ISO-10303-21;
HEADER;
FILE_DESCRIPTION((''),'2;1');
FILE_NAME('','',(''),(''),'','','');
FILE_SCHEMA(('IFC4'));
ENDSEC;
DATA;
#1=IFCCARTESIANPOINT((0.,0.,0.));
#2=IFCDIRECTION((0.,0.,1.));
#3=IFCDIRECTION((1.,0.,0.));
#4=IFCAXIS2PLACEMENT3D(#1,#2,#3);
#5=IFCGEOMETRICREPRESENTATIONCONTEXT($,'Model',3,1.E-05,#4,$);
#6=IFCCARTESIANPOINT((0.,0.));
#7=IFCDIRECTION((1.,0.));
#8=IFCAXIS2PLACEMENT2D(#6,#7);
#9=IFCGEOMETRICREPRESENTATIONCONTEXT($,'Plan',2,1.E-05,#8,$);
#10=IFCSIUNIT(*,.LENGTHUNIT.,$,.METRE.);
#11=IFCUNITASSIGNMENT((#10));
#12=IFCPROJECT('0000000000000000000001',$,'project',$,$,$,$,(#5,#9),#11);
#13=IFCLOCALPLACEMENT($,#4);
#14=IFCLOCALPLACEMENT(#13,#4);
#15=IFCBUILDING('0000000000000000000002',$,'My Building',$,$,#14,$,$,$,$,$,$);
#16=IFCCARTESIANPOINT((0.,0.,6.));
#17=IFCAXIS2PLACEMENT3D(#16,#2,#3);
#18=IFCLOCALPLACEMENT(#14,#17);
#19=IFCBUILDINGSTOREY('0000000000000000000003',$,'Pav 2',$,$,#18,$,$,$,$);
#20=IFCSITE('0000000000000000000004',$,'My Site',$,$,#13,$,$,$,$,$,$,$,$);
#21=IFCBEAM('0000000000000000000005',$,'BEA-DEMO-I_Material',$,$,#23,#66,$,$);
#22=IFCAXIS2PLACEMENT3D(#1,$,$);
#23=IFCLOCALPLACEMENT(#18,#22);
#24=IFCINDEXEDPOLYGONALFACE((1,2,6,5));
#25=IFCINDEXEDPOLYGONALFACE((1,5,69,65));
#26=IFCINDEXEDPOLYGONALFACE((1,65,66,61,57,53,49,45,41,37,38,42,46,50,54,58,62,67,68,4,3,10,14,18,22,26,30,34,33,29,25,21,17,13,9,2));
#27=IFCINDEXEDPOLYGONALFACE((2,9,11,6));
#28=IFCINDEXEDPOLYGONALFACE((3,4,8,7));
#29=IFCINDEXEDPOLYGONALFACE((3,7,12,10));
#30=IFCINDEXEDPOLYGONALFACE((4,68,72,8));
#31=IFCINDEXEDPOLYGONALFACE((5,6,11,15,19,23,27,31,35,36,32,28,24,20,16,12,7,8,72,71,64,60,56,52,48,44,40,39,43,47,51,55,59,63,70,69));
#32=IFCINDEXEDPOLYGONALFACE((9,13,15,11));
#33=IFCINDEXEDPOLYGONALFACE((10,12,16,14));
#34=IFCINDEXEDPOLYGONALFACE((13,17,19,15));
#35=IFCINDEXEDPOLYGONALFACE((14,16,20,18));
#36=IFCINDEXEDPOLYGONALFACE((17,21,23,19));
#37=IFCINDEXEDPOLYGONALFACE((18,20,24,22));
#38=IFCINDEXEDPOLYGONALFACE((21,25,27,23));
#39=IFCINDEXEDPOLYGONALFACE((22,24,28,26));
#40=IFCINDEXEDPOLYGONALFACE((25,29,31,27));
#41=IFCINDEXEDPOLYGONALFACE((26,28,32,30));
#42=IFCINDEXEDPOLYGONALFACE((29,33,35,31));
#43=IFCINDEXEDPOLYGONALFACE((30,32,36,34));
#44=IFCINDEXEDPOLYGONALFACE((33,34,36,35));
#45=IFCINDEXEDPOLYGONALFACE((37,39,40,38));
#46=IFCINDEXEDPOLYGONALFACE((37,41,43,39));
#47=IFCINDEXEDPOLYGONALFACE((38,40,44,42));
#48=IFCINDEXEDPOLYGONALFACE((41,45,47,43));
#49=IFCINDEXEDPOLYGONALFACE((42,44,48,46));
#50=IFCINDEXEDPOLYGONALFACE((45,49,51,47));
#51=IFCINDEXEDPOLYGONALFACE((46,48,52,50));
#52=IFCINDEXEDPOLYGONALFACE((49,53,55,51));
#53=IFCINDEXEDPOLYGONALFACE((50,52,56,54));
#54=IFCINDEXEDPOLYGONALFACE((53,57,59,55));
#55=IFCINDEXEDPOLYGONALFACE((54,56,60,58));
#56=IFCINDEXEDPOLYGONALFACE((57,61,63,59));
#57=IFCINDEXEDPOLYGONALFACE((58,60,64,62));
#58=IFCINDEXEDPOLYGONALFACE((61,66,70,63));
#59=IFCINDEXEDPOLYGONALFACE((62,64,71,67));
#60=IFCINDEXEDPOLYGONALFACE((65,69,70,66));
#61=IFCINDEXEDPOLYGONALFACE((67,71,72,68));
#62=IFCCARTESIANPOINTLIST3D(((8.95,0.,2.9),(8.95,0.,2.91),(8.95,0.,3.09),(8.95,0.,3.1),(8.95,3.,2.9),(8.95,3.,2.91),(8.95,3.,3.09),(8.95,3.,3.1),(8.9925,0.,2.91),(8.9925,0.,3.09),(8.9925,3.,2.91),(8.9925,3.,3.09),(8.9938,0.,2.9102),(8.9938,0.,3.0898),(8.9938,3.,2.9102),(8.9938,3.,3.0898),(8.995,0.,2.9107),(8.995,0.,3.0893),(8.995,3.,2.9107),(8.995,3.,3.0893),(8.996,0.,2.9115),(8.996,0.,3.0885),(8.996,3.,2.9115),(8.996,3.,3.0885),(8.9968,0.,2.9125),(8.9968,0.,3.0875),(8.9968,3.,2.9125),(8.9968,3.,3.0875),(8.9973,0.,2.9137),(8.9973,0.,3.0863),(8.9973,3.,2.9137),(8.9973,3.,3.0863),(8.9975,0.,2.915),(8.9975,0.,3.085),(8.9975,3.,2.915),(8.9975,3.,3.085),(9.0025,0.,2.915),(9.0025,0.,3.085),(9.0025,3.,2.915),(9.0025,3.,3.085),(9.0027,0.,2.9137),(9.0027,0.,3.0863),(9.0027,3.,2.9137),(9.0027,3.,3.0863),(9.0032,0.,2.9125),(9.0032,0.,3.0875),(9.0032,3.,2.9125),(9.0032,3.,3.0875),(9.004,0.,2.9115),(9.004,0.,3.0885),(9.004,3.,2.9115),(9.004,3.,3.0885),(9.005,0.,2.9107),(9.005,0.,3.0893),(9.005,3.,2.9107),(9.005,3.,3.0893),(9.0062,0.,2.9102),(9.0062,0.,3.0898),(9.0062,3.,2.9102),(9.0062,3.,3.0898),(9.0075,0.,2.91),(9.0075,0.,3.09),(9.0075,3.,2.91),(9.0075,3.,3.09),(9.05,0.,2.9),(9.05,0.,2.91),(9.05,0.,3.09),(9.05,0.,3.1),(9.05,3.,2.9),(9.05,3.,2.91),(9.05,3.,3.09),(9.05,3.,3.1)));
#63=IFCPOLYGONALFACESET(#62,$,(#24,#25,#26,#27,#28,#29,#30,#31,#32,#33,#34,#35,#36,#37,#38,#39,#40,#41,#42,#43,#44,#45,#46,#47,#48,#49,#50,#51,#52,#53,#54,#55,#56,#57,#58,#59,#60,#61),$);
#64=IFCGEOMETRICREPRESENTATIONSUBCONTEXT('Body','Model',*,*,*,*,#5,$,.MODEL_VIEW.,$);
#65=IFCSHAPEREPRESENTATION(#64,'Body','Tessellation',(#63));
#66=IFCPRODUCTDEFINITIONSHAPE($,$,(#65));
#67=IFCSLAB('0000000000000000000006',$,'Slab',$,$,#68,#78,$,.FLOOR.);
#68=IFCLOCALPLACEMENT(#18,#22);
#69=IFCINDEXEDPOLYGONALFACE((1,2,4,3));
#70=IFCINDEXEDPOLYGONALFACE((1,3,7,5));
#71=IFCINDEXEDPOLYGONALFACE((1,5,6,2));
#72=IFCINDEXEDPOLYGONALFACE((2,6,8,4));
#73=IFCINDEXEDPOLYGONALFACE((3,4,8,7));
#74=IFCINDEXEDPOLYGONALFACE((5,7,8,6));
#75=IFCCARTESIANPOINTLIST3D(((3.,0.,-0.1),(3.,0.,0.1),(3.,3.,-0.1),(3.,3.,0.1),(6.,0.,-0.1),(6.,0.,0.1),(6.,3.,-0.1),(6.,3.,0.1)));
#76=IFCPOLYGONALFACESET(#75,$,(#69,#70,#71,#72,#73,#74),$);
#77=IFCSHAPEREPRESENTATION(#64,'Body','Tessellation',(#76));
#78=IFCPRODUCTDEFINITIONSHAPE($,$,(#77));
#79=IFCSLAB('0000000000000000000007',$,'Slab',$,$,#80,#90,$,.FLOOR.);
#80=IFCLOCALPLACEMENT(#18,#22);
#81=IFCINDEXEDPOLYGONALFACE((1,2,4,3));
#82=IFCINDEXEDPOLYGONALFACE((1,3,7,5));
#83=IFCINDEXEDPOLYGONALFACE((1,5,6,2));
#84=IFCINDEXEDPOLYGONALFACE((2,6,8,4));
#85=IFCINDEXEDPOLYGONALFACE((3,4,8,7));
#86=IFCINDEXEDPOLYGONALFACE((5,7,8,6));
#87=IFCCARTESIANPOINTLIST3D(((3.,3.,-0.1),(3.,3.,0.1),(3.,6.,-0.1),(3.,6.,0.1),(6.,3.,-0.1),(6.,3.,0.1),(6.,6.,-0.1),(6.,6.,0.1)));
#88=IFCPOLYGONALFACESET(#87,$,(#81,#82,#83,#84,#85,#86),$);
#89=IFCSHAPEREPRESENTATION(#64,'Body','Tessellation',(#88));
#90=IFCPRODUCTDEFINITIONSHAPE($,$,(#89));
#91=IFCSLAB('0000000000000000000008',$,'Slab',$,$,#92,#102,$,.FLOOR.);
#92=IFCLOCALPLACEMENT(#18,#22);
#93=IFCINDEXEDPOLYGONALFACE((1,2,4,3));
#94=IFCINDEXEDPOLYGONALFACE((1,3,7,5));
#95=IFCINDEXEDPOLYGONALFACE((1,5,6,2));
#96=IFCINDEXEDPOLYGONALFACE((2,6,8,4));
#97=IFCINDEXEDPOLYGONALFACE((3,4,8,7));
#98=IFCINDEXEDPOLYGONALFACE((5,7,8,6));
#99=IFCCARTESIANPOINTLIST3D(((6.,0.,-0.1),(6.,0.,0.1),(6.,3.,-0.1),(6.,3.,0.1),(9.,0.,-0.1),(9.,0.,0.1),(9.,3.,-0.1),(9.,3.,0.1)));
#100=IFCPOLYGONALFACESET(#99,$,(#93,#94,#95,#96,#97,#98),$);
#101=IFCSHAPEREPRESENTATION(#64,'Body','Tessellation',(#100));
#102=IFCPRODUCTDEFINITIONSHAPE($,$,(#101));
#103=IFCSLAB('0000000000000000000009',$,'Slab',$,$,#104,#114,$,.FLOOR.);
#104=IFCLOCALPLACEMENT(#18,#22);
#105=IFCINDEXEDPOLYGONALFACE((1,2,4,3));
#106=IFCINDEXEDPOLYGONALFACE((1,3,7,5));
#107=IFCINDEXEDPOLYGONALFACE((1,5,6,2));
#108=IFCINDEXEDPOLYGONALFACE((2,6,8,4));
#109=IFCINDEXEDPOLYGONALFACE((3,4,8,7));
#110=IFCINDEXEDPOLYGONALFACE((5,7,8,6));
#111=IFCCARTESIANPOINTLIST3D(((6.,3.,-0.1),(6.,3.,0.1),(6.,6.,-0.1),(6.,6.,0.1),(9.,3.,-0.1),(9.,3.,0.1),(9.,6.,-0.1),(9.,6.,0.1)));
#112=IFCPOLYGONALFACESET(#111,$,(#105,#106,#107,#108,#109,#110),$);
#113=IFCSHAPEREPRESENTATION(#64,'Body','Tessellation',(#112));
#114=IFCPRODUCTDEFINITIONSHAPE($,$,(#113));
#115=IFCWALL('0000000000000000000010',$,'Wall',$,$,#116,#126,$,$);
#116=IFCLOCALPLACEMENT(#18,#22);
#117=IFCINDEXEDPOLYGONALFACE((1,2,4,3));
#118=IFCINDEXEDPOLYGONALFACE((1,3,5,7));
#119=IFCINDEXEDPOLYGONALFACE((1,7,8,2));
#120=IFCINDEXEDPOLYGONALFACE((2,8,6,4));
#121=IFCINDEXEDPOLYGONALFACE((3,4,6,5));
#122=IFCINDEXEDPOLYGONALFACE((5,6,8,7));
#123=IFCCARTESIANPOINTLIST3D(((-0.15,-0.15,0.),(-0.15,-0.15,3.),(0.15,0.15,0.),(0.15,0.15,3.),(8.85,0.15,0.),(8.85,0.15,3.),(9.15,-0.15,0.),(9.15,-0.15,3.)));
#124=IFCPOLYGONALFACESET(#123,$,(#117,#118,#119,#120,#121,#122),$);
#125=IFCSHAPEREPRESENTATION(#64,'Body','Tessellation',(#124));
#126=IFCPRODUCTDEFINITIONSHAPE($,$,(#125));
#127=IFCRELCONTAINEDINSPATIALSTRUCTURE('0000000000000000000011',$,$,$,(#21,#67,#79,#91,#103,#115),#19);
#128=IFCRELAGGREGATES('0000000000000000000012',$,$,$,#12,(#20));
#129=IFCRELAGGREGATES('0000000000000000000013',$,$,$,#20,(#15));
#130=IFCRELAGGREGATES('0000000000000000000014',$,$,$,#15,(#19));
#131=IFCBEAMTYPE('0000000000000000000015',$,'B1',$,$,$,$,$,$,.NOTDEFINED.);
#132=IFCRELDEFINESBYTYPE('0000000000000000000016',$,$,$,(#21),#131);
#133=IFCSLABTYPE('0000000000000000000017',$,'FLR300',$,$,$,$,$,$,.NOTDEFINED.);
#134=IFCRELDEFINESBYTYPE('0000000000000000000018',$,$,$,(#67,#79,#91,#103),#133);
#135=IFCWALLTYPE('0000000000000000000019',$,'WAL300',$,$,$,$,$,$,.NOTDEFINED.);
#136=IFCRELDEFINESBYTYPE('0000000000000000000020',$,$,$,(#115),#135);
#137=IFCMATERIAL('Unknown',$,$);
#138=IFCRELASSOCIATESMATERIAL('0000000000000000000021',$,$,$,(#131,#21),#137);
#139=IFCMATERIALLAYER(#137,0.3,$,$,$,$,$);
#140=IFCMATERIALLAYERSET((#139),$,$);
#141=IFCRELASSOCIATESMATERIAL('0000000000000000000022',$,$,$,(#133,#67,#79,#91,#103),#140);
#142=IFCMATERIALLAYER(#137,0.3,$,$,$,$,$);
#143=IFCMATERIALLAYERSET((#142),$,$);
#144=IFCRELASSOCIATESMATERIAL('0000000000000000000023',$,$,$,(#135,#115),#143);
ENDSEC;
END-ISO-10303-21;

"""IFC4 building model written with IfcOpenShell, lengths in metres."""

from ifc_helpers import new_model, si_unit, frame, origin, origin_with_axes, origin_2d_with_axis, place, context, subcontext, project, spatial, polyline, line, indexed_curve, i_section, outline, extrude, material, layer, layer_set, layer_usage, material_profile, profile_set, profile_usage, type_object, element, save


model = new_model("IFC4")

# Units and contexts
model_context = context("Model", 3, precision=1e-05, world=origin_with_axes())
plan_context = context("Plan", 2, precision=1e-05, world=origin_2d_with_axis())
body_context = subcontext(model_context, "Body", "Model", "MODEL_VIEW")
ifc_project = project(units=[si_unit("LENGTHUNIT", "METRE")], contexts=[model_context, plan_context])

# Site, building, storey
site_placement = place(None, origin_with_axes())
site = spatial("IfcSite", under=ifc_project, at=site_placement, Name="My Site")
building_placement = place(site_placement, origin_with_axes())
building = spatial("IfcBuilding", under=site, at=building_placement, Name="My Building")
storey_placement = place(building_placement, frame((0.0, 0.0, 6.0), z_axis=(0.0, 0.0, 1.0), x_axis=(1.0, 0.0, 0.0)))
storey = spatial("IfcBuildingStorey", under=building, at=storey_placement, Name="Pav 2")

# Beam
ifc_material = material(Name="Unknown")
ifc_material_profile = material_profile(ifc_material, i_section(OverallWidth=0.1, OverallDepth=0.2, WebThickness=0.005, FlangeThickness=0.01, FilletRadius=0.005))
ifc_profile_set = profile_set([ifc_material_profile])
beam_type = type_object("IfcBeamType", Name="B1", PredefinedType="NOTDEFINED", material=ifc_profile_set)
ifc_profile_usage_1 = profile_usage(ifc_profile_set, cardinal=5)
beam_1_placement = place(storey_placement, frame((9.0, 3.0, 3.0), z_axis=(0.0, -1.0, 0.0), x_axis=(1.0, 0.0, 0.0)))
element("IfcBeam", 1, at=beam_1_placement, inside=storey, type_object=beam_type, material=ifc_profile_usage_1, Name="BEA-DEMO-I_Material", context=body_context, shape_type="SweptSolid", body=[
    extrude(i_section(OverallWidth=0.1, OverallDepth=0.2, WebThickness=0.005, FlangeThickness=0.01, FilletRadius=0.005), origin(), (0.0, 0.0, 1.0), 3.0),
])

# Slabs
ifc_layer_1 = layer(ifc_material, 0.3)
ifc_layer_set_1 = layer_set([ifc_layer_1])
ifc_layer_usage_1 = layer_usage(ifc_layer_set_1, "AXIS3", "POSITIVE", 0.0)
slab_type = type_object("IfcSlabType", Name="FLR300", PredefinedType="NOTDEFINED", material=ifc_layer_set_1)
slab_1_placement = place(storey_placement, frame((4.5, 1.5, -0.1), z_axis=(0.0, 0.0, 1.0), x_axis=(1.0, 0.0, 0.0)))
element("IfcSlab", 2, at=slab_1_placement, inside=storey, type_object=slab_type, material=ifc_layer_usage_1, Name="Slab", PredefinedType="FLOOR", context=body_context, shape_type="SweptSolid", body=[
    extrude(outline(polyline([(1.5, 1.5), (-1.5, 1.5), (-1.5, -1.5), (1.5, -1.5), (1.5, 1.5)])), origin(), (0.0, 0.0, 1.0), 0.2),
])
ifc_layer_usage_2 = layer_usage(ifc_layer_set_1, "AXIS3", "POSITIVE", 0.0)
slab_2_placement = place(storey_placement, frame((4.5, 4.5, -0.1), z_axis=(0.0, 0.0, 1.0), x_axis=(1.0, 0.0, 0.0)))
element("IfcSlab", 3, at=slab_2_placement, inside=storey, type_object=slab_type, material=ifc_layer_usage_2, Name="Slab", PredefinedType="FLOOR", context=body_context, shape_type="SweptSolid", body=[
    extrude(outline(polyline([(1.5, 1.5), (-1.5, 1.5), (-1.5, -1.5), (1.5, -1.5), (1.5, 1.5)])), origin(), (0.0, 0.0, 1.0), 0.2),
])
ifc_layer_usage_3 = layer_usage(ifc_layer_set_1, "AXIS3", "POSITIVE", 0.0)
slab_3_placement = place(storey_placement, frame((7.5, 1.5, -0.1), z_axis=(0.0, 0.0, 1.0), x_axis=(1.0, 0.0, 0.0)))
element("IfcSlab", 4, at=slab_3_placement, inside=storey, type_object=slab_type, material=ifc_layer_usage_3, Name="Slab", PredefinedType="FLOOR", context=body_context, shape_type="SweptSolid", body=[
    extrude(outline(polyline([(1.5, 1.5), (-1.5, 1.5), (-1.5, -1.5), (1.5, -1.5), (1.5, 1.5)])), origin(), (0.0, 0.0, 1.0), 0.2),
])
ifc_layer_usage_4 = layer_usage(ifc_layer_set_1, "AXIS3", "POSITIVE", 0.0)
slab_4_placement = place(storey_placement, frame((7.5, 4.5, -0.1), z_axis=(0.0, 0.0, 1.0), x_axis=(1.0, 0.0, 0.0)))
element("IfcSlab", 5, at=slab_4_placement, inside=storey, type_object=slab_type, material=ifc_layer_usage_4, Name="Slab", PredefinedType="FLOOR", context=body_context, shape_type="SweptSolid", body=[
    extrude(outline(polyline([(1.5, 1.5), (-1.5, 1.5), (-1.5, -1.5), (1.5, -1.5), (1.5, 1.5)])), origin(), (0.0, 0.0, 1.0), 0.2),
])

# Wall
ifc_layer_2 = layer(ifc_material, 0.3)
ifc_layer_set_2 = layer_set([ifc_layer_2])
ifc_layer_usage_5 = layer_usage(ifc_layer_set_2, "AXIS2", "POSITIVE", -0.15)
wall_type = type_object("IfcWallType", Name="WAL300", PredefinedType="NOTDEFINED", material=ifc_layer_set_2)
wall_placement = place(storey_placement, frame((9.0, 0.0, 0.0), z_axis=(0.0, 0.0, 1.0), x_axis=(-1.0, 0.0, 0.0)))
element("IfcWall", 6, at=wall_placement, inside=storey, type_object=wall_type, material=ifc_layer_usage_5, Name="Wall", context=body_context, shape_type="SweptSolid", body=[
    extrude(outline(indexed_curve([(0.15, -0.15), (-0.15, 0.15), (9.15, 0.15), (8.85, -0.15)], segments=[line(1, 2, 3, 4, 1)])), origin_with_axes(), (0.0, 0.0, 1.0), 3.0),
])

save(model, "model.ifc")
